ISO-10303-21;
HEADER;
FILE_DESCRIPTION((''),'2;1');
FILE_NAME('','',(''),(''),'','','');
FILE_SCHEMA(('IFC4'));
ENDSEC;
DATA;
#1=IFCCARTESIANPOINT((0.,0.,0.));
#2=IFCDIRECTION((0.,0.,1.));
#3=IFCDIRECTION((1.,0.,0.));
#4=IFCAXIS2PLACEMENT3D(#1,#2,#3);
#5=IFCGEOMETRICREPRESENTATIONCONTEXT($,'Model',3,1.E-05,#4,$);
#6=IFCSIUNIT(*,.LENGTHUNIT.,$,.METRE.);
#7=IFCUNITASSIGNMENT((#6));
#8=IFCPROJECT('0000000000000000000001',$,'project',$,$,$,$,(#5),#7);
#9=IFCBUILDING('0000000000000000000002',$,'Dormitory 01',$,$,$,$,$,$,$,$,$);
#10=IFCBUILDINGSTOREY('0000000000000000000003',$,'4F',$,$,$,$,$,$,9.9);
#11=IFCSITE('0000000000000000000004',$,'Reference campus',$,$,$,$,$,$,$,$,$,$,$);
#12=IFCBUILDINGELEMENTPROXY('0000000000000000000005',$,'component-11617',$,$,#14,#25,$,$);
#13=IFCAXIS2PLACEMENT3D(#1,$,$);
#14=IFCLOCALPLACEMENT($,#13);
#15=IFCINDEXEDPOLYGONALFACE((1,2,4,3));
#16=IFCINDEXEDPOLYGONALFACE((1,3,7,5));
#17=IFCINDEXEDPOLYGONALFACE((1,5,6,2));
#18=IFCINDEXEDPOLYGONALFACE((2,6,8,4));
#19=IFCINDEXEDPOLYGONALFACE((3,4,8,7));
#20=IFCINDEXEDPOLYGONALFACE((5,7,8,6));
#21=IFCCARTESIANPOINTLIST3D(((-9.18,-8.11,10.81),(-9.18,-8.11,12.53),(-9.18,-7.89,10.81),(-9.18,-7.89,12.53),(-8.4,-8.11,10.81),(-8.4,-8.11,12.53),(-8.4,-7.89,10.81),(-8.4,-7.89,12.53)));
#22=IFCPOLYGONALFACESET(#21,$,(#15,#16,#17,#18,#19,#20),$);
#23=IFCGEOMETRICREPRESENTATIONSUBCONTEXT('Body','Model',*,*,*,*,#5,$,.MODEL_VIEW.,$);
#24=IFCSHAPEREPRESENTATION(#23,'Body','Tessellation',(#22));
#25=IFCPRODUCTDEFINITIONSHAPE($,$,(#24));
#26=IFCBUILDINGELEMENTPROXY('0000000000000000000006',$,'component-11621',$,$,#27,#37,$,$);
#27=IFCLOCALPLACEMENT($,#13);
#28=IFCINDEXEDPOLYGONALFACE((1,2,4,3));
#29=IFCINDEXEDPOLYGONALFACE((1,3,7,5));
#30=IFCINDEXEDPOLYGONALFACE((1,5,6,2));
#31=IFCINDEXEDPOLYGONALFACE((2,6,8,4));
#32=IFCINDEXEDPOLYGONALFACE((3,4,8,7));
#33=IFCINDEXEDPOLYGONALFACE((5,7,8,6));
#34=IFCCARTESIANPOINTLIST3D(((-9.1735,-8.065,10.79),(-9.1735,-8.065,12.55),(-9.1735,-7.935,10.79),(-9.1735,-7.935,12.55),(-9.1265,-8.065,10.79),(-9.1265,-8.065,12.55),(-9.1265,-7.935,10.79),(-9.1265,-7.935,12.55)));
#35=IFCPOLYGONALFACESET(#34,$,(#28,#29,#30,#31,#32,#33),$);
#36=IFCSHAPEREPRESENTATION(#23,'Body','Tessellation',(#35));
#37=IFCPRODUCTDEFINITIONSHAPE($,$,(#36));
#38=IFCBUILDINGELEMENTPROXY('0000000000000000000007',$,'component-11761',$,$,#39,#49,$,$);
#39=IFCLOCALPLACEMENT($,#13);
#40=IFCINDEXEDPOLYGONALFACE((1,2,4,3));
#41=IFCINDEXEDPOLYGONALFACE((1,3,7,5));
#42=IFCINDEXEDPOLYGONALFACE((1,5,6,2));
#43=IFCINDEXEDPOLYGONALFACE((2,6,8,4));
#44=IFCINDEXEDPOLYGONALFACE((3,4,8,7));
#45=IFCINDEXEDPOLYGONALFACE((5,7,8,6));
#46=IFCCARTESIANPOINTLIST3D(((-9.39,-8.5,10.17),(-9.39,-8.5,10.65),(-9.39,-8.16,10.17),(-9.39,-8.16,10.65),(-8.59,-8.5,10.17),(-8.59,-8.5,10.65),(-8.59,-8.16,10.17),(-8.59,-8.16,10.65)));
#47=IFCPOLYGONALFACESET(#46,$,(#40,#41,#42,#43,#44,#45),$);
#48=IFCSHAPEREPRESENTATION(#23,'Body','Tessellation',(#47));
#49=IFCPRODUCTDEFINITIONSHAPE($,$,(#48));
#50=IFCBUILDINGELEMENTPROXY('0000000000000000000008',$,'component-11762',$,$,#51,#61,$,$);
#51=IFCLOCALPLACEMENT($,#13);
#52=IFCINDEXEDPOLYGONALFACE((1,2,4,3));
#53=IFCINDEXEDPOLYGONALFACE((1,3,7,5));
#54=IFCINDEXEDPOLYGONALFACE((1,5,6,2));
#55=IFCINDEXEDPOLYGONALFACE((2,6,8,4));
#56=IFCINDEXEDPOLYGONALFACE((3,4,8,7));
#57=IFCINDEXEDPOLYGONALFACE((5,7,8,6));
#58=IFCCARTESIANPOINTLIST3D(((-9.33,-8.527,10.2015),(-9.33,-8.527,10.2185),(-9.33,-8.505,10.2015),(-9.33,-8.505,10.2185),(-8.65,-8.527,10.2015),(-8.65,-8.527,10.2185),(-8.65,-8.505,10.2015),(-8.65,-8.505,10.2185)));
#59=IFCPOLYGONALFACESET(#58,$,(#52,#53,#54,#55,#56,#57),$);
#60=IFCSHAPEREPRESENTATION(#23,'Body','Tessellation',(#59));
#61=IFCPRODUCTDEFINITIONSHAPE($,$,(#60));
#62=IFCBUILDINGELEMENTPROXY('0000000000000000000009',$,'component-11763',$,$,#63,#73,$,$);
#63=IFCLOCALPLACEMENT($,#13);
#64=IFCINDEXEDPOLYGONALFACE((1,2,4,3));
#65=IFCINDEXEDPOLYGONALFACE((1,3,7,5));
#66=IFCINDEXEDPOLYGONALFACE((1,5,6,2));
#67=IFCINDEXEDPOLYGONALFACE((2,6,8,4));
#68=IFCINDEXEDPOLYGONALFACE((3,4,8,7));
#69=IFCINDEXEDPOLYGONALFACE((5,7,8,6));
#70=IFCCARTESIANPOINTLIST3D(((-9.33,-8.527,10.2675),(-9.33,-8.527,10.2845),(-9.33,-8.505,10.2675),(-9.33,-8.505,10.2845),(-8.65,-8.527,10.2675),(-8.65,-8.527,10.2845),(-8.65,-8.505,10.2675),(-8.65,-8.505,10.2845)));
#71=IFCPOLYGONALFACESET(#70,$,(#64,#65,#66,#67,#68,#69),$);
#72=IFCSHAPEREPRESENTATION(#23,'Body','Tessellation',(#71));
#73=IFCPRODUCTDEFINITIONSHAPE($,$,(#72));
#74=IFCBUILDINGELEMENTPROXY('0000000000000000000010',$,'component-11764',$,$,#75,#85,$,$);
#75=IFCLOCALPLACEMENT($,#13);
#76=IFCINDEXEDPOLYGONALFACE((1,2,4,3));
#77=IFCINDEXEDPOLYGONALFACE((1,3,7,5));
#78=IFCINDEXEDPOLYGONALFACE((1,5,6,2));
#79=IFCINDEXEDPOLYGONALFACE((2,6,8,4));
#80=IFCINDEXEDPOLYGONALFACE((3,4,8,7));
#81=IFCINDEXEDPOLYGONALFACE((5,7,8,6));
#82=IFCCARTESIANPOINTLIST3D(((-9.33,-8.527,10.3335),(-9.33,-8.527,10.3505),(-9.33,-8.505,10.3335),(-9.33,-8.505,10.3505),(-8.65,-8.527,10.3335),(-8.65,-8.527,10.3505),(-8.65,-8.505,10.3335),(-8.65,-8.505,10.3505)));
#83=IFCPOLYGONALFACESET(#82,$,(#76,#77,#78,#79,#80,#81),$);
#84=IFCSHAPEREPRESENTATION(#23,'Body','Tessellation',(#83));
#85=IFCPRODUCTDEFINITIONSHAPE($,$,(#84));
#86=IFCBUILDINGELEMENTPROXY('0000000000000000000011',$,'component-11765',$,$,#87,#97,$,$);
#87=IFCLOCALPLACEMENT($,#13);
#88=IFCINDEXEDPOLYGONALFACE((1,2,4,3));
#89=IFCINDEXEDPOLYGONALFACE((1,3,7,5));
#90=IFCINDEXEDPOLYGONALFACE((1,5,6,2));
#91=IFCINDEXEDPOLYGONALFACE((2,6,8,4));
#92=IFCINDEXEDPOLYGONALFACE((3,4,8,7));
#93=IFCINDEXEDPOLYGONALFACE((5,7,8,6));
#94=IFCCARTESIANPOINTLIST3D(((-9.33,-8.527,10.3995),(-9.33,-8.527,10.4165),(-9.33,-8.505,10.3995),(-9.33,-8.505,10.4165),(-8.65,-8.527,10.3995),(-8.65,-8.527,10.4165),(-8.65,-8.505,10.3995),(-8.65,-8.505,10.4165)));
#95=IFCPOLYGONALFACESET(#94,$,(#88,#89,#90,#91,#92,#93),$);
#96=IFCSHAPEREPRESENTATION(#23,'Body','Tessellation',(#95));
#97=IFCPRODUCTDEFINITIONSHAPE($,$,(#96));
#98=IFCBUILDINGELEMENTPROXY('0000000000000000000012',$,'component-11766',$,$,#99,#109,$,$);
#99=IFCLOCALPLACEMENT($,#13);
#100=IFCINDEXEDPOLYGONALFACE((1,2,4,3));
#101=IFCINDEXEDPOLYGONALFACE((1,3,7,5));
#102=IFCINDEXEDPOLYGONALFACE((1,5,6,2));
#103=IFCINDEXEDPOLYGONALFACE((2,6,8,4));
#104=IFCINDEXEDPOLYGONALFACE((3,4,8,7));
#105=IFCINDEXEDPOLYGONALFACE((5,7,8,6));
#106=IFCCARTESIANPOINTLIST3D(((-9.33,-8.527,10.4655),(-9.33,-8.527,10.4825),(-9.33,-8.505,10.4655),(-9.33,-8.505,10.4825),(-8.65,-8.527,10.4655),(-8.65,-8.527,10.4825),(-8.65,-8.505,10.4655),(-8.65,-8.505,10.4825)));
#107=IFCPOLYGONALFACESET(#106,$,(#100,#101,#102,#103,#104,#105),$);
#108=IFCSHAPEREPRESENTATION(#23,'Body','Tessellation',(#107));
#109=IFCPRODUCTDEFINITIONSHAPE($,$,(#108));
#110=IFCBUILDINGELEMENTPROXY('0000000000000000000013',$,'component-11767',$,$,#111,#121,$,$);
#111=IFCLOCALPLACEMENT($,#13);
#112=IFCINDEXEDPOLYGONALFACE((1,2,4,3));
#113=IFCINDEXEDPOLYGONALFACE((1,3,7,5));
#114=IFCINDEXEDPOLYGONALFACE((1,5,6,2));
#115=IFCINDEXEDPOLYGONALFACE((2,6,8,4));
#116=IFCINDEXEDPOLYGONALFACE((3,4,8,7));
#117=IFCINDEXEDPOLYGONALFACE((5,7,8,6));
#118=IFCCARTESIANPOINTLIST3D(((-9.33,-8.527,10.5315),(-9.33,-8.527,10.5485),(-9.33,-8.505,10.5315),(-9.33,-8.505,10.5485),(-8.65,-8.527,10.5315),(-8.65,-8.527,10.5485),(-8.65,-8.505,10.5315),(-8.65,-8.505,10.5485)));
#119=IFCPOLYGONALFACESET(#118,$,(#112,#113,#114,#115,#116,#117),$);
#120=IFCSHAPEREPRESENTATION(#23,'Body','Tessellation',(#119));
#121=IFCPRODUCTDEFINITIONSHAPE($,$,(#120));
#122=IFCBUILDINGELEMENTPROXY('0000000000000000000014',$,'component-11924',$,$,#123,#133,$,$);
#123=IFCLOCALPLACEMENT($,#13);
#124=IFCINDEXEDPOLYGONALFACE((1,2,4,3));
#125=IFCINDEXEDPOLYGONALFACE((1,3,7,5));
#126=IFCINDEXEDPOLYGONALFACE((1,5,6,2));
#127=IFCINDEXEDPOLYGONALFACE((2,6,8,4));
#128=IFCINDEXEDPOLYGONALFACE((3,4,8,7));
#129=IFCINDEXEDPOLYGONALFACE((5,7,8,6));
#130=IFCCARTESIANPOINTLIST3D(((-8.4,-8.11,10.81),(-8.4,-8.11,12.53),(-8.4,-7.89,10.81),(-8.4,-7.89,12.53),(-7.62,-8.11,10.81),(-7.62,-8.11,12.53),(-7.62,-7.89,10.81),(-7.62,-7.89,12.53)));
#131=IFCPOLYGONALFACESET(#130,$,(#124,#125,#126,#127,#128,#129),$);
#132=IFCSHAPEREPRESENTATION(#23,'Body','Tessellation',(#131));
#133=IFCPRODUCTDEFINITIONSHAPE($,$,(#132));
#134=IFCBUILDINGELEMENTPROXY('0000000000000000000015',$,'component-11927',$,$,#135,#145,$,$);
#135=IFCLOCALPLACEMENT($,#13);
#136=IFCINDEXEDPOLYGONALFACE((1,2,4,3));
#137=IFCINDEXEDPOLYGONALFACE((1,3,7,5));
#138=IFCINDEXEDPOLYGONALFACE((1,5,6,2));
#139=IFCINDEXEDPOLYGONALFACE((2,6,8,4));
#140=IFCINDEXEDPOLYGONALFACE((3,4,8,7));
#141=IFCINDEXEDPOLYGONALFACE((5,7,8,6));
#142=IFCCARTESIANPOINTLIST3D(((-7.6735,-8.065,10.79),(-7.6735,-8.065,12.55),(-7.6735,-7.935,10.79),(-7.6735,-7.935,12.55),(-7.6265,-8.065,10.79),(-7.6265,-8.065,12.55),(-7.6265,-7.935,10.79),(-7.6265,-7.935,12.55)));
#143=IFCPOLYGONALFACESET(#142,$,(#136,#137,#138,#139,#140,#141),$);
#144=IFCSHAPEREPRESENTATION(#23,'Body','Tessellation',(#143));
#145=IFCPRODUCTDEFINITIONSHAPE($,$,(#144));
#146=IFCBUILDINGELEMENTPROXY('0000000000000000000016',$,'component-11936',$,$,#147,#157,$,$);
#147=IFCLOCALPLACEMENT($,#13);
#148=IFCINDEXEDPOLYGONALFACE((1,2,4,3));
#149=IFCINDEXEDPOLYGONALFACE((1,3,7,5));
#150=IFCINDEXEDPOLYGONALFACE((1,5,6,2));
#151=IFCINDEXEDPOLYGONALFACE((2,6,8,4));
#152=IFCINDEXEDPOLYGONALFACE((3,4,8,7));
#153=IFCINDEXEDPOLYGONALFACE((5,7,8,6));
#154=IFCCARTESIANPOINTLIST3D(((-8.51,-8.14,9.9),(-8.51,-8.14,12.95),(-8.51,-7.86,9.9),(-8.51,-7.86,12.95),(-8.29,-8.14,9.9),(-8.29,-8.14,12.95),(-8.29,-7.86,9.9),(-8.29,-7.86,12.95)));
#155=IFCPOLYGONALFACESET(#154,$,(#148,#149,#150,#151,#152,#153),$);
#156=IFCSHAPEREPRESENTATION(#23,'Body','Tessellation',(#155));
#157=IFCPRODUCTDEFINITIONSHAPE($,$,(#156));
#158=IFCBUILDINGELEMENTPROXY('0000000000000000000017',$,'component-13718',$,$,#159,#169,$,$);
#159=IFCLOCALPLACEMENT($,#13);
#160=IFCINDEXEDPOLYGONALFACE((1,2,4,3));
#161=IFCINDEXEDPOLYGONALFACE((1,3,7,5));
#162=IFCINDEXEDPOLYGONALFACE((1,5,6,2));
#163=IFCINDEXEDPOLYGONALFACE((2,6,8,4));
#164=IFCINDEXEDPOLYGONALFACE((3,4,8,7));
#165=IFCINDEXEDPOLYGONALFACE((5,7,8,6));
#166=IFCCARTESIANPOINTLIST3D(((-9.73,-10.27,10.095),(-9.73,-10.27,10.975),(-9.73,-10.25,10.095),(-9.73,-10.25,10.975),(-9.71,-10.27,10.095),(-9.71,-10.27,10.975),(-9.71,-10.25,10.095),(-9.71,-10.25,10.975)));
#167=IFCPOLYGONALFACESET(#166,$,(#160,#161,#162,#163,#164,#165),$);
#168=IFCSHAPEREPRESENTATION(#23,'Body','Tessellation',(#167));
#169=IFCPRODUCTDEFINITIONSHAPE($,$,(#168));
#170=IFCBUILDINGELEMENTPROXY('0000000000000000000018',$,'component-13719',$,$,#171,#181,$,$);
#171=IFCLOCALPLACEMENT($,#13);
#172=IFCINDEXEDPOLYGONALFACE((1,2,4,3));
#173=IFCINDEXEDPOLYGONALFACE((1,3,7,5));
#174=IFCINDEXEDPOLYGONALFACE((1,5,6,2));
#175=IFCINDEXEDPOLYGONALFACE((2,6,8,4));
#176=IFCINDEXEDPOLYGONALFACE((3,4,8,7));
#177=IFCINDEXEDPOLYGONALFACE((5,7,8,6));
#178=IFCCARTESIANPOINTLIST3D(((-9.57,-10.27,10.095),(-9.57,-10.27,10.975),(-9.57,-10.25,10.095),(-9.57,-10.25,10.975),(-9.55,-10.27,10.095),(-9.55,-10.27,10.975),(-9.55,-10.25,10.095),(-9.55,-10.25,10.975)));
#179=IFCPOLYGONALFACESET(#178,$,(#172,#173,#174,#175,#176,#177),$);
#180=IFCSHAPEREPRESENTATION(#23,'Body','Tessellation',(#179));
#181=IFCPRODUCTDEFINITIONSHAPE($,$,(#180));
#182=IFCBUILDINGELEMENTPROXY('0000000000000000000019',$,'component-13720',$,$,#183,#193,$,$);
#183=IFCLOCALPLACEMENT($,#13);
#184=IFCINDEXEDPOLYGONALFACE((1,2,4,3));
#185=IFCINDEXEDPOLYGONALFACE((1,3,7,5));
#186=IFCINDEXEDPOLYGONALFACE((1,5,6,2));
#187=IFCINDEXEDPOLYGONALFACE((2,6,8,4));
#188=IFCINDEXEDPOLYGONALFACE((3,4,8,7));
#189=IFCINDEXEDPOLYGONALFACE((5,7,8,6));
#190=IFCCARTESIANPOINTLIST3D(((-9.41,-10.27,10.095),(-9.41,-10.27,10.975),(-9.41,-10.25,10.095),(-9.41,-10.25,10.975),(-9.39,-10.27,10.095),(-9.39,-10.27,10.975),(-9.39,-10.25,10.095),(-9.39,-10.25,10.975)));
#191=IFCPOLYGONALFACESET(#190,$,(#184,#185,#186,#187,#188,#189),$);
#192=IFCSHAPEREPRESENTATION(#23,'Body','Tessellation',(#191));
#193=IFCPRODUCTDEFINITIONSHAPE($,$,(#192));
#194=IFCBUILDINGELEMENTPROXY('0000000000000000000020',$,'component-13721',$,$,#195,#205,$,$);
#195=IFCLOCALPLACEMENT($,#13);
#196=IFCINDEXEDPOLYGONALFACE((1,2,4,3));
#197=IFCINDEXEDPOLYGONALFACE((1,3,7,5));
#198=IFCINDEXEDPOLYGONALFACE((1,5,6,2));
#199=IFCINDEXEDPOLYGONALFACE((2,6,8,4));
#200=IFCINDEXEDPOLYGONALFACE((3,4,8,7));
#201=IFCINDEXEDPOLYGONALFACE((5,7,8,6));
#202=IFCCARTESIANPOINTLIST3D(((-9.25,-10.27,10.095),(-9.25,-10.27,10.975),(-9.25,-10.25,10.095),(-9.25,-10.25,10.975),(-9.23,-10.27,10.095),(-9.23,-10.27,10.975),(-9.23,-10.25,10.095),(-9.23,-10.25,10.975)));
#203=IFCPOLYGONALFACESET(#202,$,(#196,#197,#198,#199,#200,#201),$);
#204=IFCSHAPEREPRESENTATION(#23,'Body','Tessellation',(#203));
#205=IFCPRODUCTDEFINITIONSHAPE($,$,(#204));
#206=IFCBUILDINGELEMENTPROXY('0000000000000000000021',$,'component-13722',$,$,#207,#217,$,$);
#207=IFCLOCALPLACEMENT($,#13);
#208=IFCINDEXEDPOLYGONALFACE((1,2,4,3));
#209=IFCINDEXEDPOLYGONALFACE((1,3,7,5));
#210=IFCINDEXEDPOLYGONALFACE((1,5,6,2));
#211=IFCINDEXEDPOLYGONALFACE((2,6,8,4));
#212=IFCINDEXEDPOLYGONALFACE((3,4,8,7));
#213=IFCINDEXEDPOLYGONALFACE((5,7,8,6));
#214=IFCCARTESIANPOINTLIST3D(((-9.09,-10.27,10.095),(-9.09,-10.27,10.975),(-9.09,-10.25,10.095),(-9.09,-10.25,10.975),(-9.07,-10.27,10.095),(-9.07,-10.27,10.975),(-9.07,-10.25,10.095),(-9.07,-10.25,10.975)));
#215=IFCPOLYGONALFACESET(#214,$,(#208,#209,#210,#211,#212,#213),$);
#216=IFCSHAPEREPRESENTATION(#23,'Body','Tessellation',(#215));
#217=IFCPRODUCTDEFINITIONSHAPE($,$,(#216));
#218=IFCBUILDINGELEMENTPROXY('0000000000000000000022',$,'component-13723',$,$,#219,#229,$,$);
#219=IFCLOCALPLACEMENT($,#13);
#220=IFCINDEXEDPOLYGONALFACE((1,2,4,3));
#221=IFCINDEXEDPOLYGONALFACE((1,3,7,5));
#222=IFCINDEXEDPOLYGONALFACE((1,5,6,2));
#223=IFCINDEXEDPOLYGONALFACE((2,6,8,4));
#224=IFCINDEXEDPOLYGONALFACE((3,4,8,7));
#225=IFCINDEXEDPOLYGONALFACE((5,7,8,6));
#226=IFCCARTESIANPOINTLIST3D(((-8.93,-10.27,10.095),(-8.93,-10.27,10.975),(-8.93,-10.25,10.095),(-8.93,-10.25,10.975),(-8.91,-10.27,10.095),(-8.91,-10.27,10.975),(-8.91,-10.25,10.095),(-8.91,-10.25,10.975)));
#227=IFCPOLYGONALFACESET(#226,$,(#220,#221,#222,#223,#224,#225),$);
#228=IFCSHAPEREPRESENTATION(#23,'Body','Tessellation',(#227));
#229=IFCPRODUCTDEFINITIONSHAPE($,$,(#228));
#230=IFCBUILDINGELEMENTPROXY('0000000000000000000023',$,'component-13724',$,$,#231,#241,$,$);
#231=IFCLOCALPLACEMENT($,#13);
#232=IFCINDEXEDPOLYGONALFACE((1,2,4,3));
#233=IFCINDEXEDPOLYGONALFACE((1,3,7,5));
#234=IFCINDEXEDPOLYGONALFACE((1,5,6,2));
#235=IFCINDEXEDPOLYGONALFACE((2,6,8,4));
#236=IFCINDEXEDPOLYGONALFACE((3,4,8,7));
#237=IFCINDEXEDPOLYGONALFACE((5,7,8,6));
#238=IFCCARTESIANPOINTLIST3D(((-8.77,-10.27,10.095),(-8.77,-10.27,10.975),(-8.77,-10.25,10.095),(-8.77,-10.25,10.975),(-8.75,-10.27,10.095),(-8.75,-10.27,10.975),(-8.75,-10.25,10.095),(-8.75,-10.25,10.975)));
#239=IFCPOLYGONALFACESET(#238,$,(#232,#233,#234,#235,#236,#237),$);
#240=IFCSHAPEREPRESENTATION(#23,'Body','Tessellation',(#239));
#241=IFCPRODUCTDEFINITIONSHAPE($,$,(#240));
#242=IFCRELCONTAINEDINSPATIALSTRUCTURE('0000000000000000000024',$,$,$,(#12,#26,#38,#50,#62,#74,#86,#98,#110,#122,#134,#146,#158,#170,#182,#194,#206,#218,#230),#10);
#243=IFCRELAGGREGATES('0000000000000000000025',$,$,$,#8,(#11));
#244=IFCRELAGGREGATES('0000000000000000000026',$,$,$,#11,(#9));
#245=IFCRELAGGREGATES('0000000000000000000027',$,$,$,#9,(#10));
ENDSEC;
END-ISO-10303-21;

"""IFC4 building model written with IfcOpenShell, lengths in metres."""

from ifc_helpers import new_model, si_unit, frame, origin, origin_with_axes, origin_2d, place, context, subcontext, project, spatial, rectangle, extrude, element, save


model = new_model("IFC4")

# Units and contexts
model_context = context("Model", 3, precision=1e-05, world=origin_with_axes())
body_context = subcontext(model_context, "Body", "Model", "MODEL_VIEW")
ifc_project = project(units=[si_unit("LENGTHUNIT", "METRE")], contexts=[model_context])

# Site, building, storey
site = spatial("IfcSite", under=ifc_project, Name="Reference campus")
building = spatial("IfcBuilding", under=site, Name="Dormitory 01")
storey = spatial("IfcBuildingStorey", under=building, Name="4F", Elevation=9.9)

# Building element proxies
proxy_1_placement = place(None, frame((-8.79, -8.0, 10.81), z_axis=(0.0, 0.0, 1.0), x_axis=(1.0, 0.0, 0.0)))
element("IfcBuildingElementProxy", 1, at=proxy_1_placement, inside=storey, Name="component-11617", context=body_context, shape_type="SweptSolid", body=[
    extrude(rectangle(XDim=0.78, YDim=0.22, at=origin_2d()), origin(), (0.0, 0.0, 1.0), 1.72),
])
proxy_2_placement = place(None, frame((-9.15, -8.0, 10.79), z_axis=(0.0, 0.0, 1.0), x_axis=(1.0, 0.0, 0.0)))
element("IfcBuildingElementProxy", 2, at=proxy_2_placement, inside=storey, Name="component-11621", context=body_context, shape_type="SweptSolid", body=[
    extrude(rectangle(XDim=0.047, YDim=0.13, at=origin_2d()), origin(), (0.0, 0.0, 1.0), 1.76),
])
proxy_3_placement = place(None, frame((-8.99, -8.33, 10.17), z_axis=(0.0, 0.0, 1.0), x_axis=(1.0, 0.0, 0.0)))
element("IfcBuildingElementProxy", 3, at=proxy_3_placement, inside=storey, Name="component-11761", context=body_context, shape_type="SweptSolid", body=[
    extrude(rectangle(XDim=0.8, YDim=0.34, at=origin_2d()), origin(), (0.0, 0.0, 1.0), 0.48),
])
for number, where, z_axis, x_axis, name in (
    (4, (-8.99, -8.516, 10.2015), (0.0, 0.0, 1.0), (1.0, 0.0, 0.0), "component-11762"),
    (5, (-8.99, -8.516, 10.2675), (0.0, 0.0, 1.0), (1.0, 0.0, 0.0), "component-11763"),
    (6, (-8.99, -8.516, 10.3335), (0.0, 0.0, 1.0), (1.0, 0.0, 0.0), "component-11764"),
    (7, (-8.99, -8.516, 10.3995), (0.0, 0.0, 1.0), (1.0, 0.0, 0.0), "component-11765"),
    (8, (-8.99, -8.516, 10.4655), (0.0, 0.0, 1.0), (1.0, 0.0, 0.0), "component-11766"),
    (9, (-8.99, -8.516, 10.5315), (0.0, 0.0, 1.0), (1.0, 0.0, 0.0), "component-11767"),
):
    element("IfcBuildingElementProxy", number, at=place(None, frame(where, z_axis=z_axis, x_axis=x_axis)), inside=storey, Name=name, context=body_context, shape_type="SweptSolid", body=[
        extrude(rectangle(XDim=0.68, YDim=0.022, at=origin_2d()), origin(), (0.0, 0.0, 1.0), 0.017),
    ])
proxy_4_placement = place(None, frame((-8.01, -8.0, 10.81), z_axis=(0.0, 0.0, 1.0), x_axis=(1.0, 0.0, 0.0)))
element("IfcBuildingElementProxy", 10, at=proxy_4_placement, inside=storey, Name="component-11924", context=body_context, shape_type="SweptSolid", body=[
    extrude(rectangle(XDim=0.78, YDim=0.22, at=origin_2d()), origin(), (0.0, 0.0, 1.0), 1.72),
])
proxy_5_placement = place(None, frame((-7.65, -8.0, 10.79), z_axis=(0.0, 0.0, 1.0), x_axis=(1.0, 0.0, 0.0)))
element("IfcBuildingElementProxy", 11, at=proxy_5_placement, inside=storey, Name="component-11927", context=body_context, shape_type="SweptSolid", body=[
    extrude(rectangle(XDim=0.047, YDim=0.13, at=origin_2d()), origin(), (0.0, 0.0, 1.0), 1.76),
])
proxy_6_placement = place(None, frame((-8.4, -8.0, 9.9), z_axis=(0.0, 0.0, 1.0), x_axis=(1.0, 0.0, 0.0)))
element("IfcBuildingElementProxy", 12, at=proxy_6_placement, inside=storey, Name="component-11936", context=body_context, shape_type="SweptSolid", body=[
    extrude(rectangle(XDim=0.22, YDim=0.28, at=origin_2d()), origin(), (0.0, 0.0, 1.0), 3.05),
])
for number, where, z_axis, x_axis, name in (
    (13, (-9.72, -10.26, 10.095), (0.0, 0.0, 1.0), (1.0, 0.0, 0.0), "component-13718"),
    (14, (-9.56, -10.26, 10.095), (0.0, 0.0, 1.0), (1.0, 0.0, 0.0), "component-13719"),
    (15, (-9.4, -10.26, 10.095), (0.0, 0.0, 1.0), (1.0, 0.0, 0.0), "component-13720"),
    (16, (-9.24, -10.26, 10.095), (0.0, 0.0, 1.0), (1.0, 0.0, 0.0), "component-13721"),
    (17, (-9.08, -10.26, 10.095), (0.0, 0.0, 1.0), (1.0, 0.0, 0.0), "component-13722"),
    (18, (-8.92, -10.26, 10.095), (0.0, 0.0, 1.0), (1.0, 0.0, 0.0), "component-13723"),
    (19, (-8.76, -10.26, 10.095), (0.0, 0.0, 1.0), (1.0, 0.0, 0.0), "component-13724"),
):
    element("IfcBuildingElementProxy", number, at=place(None, frame(where, z_axis=z_axis, x_axis=x_axis)), inside=storey, Name=name, context=body_context, shape_type="SweptSolid", body=[
        extrude(rectangle(XDim=0.02, YDim=0.02, at=origin_2d()), origin(), (0.0, 0.0, 1.0), 0.88),
    ])

save(model, "model.ifc")
